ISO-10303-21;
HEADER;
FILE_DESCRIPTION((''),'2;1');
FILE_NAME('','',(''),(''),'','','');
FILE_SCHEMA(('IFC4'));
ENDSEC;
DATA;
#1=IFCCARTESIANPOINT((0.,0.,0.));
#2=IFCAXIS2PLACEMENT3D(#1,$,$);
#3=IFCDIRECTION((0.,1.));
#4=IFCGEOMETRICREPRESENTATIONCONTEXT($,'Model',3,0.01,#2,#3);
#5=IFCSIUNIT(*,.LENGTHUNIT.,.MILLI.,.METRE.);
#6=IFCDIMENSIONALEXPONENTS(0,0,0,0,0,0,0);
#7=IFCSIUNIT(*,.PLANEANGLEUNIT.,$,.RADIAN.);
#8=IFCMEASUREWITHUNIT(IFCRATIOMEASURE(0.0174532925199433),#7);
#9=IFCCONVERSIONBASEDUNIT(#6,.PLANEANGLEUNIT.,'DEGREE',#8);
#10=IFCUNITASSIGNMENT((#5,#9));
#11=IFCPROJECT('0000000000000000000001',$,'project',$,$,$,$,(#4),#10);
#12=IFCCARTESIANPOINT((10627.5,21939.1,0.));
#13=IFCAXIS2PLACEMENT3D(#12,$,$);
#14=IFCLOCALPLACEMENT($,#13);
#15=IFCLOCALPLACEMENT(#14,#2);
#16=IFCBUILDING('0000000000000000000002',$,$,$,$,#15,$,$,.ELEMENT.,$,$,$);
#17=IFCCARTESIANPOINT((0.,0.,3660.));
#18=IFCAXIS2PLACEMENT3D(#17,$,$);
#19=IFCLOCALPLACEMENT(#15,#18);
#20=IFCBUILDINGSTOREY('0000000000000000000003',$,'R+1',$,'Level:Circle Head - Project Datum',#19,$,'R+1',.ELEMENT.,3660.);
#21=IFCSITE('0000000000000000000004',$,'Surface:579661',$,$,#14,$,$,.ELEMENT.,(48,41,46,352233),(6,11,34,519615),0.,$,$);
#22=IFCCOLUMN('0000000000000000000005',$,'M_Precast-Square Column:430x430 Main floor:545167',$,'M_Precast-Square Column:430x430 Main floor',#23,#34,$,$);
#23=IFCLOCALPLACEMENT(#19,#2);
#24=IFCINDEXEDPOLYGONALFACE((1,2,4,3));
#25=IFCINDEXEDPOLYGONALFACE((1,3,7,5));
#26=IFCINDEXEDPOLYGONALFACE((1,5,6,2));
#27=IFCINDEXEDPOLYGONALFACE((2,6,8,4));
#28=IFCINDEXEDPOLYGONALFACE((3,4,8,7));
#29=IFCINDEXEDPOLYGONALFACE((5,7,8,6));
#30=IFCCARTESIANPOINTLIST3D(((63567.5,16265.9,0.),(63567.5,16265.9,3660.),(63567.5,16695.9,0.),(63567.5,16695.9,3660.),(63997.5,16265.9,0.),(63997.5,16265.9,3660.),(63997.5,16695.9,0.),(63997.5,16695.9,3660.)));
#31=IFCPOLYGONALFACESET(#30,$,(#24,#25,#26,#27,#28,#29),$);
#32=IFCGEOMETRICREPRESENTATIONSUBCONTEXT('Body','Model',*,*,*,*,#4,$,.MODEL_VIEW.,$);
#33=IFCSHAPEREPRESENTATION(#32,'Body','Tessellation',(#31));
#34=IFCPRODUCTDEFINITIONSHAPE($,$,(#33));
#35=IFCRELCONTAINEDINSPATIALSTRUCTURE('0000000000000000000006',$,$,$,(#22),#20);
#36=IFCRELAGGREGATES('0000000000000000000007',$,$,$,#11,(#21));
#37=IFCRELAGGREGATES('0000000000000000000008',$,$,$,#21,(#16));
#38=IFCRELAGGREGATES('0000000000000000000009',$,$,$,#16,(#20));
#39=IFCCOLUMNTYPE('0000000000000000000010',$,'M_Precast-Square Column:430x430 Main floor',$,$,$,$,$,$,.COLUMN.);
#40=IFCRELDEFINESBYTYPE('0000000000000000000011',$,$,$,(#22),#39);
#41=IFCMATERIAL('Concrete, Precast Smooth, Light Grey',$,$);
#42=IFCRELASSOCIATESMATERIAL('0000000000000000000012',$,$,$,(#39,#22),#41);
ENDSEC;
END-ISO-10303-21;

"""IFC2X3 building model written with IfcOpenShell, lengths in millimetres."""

from ifc_helpers import new_model, entity, si_unit, converted_unit, direction, frame, origin, origin_2d_with_axis, place, context, subcontext, project, spatial, rectangle, extrude, source, transform, mapped, material, type_object, type_shapes, element, save


model = new_model("IFC2X3")

# Units and contexts
model_context = context("Model", 3, precision=0.01, world=origin(), true_north=direction((0.0, 1.0)))
body_context = subcontext(model_context, "Body", "Model", "MODEL_VIEW")
ifc_project = project(units=[si_unit("LENGTHUNIT", "METRE", prefix="MILLI"), converted_unit("PLANEANGLEUNIT", "DEGREE", entity("IfcRatioMeasure", 0.0174532925199433), si_unit("PLANEANGLEUNIT", "RADIAN"), dimensions=[0, 0, 0, 0, 0, 0, 0])], contexts=[model_context])

# Site, building, storey
site_placement = place(None, frame((10627.5, 21939.1, 0.0)))
site = spatial("IfcSite", under=ifc_project, at=site_placement, Name="Surface:579661", CompositionType="ELEMENT", RefLatitude=(48, 41, 46, 352233), RefLongitude=(6, 11, 34, 519615), RefElevation=0.0)
building_placement = place(site_placement, origin())
building = spatial("IfcBuilding", under=site, at=building_placement, CompositionType="ELEMENT")
storey_placement = place(building_placement, frame((0.0, 0.0, 3660.0)))
storey = spatial("IfcBuildingStorey", under=building, at=storey_placement, Name="R+1", ObjectType="Level:Circle Head - Project Datum", LongName="R+1", CompositionType="ELEMENT", Elevation=3660.0)

# Column
ifc_material = material(Name="Concrete, Precast Smooth, Light Grey")
column_type = type_object("IfcColumnType", Name="M_Precast-Square Column:430x430 Main floor", PredefinedType="COLUMN", material=ifc_material)
shared_shape = source(origin(), body_context, "Body", "SweptSolid", [
    extrude(rectangle(XDim=430.0, YDim=430.0, at=origin_2d_with_axis()), frame((0.0, 0.0, 3660.0), z_axis=(0.0, 0.0, 1.0), x_axis=(0.0, -1.0, 0.0)), (0.0, 0.0, 1.0), 3660.0),
])
type_shapes(column_type, [shared_shape])
column_placement = place(storey_placement, frame((63782.5, 16480.9, -3660.0)))
element("IfcColumn", 1, at=column_placement, inside=storey, type_object=column_type, material=ifc_material, Name="M_Precast-Square Column:430x430 Main floor:545167", ObjectType="M_Precast-Square Column:430x430 Main floor", context=body_context, shape_type="MappedRepresentation", body=[
    mapped(shared_shape, transform((0.0, 0.0, 0.0), scale=1.0)),
])

save(model, "model.ifc")
